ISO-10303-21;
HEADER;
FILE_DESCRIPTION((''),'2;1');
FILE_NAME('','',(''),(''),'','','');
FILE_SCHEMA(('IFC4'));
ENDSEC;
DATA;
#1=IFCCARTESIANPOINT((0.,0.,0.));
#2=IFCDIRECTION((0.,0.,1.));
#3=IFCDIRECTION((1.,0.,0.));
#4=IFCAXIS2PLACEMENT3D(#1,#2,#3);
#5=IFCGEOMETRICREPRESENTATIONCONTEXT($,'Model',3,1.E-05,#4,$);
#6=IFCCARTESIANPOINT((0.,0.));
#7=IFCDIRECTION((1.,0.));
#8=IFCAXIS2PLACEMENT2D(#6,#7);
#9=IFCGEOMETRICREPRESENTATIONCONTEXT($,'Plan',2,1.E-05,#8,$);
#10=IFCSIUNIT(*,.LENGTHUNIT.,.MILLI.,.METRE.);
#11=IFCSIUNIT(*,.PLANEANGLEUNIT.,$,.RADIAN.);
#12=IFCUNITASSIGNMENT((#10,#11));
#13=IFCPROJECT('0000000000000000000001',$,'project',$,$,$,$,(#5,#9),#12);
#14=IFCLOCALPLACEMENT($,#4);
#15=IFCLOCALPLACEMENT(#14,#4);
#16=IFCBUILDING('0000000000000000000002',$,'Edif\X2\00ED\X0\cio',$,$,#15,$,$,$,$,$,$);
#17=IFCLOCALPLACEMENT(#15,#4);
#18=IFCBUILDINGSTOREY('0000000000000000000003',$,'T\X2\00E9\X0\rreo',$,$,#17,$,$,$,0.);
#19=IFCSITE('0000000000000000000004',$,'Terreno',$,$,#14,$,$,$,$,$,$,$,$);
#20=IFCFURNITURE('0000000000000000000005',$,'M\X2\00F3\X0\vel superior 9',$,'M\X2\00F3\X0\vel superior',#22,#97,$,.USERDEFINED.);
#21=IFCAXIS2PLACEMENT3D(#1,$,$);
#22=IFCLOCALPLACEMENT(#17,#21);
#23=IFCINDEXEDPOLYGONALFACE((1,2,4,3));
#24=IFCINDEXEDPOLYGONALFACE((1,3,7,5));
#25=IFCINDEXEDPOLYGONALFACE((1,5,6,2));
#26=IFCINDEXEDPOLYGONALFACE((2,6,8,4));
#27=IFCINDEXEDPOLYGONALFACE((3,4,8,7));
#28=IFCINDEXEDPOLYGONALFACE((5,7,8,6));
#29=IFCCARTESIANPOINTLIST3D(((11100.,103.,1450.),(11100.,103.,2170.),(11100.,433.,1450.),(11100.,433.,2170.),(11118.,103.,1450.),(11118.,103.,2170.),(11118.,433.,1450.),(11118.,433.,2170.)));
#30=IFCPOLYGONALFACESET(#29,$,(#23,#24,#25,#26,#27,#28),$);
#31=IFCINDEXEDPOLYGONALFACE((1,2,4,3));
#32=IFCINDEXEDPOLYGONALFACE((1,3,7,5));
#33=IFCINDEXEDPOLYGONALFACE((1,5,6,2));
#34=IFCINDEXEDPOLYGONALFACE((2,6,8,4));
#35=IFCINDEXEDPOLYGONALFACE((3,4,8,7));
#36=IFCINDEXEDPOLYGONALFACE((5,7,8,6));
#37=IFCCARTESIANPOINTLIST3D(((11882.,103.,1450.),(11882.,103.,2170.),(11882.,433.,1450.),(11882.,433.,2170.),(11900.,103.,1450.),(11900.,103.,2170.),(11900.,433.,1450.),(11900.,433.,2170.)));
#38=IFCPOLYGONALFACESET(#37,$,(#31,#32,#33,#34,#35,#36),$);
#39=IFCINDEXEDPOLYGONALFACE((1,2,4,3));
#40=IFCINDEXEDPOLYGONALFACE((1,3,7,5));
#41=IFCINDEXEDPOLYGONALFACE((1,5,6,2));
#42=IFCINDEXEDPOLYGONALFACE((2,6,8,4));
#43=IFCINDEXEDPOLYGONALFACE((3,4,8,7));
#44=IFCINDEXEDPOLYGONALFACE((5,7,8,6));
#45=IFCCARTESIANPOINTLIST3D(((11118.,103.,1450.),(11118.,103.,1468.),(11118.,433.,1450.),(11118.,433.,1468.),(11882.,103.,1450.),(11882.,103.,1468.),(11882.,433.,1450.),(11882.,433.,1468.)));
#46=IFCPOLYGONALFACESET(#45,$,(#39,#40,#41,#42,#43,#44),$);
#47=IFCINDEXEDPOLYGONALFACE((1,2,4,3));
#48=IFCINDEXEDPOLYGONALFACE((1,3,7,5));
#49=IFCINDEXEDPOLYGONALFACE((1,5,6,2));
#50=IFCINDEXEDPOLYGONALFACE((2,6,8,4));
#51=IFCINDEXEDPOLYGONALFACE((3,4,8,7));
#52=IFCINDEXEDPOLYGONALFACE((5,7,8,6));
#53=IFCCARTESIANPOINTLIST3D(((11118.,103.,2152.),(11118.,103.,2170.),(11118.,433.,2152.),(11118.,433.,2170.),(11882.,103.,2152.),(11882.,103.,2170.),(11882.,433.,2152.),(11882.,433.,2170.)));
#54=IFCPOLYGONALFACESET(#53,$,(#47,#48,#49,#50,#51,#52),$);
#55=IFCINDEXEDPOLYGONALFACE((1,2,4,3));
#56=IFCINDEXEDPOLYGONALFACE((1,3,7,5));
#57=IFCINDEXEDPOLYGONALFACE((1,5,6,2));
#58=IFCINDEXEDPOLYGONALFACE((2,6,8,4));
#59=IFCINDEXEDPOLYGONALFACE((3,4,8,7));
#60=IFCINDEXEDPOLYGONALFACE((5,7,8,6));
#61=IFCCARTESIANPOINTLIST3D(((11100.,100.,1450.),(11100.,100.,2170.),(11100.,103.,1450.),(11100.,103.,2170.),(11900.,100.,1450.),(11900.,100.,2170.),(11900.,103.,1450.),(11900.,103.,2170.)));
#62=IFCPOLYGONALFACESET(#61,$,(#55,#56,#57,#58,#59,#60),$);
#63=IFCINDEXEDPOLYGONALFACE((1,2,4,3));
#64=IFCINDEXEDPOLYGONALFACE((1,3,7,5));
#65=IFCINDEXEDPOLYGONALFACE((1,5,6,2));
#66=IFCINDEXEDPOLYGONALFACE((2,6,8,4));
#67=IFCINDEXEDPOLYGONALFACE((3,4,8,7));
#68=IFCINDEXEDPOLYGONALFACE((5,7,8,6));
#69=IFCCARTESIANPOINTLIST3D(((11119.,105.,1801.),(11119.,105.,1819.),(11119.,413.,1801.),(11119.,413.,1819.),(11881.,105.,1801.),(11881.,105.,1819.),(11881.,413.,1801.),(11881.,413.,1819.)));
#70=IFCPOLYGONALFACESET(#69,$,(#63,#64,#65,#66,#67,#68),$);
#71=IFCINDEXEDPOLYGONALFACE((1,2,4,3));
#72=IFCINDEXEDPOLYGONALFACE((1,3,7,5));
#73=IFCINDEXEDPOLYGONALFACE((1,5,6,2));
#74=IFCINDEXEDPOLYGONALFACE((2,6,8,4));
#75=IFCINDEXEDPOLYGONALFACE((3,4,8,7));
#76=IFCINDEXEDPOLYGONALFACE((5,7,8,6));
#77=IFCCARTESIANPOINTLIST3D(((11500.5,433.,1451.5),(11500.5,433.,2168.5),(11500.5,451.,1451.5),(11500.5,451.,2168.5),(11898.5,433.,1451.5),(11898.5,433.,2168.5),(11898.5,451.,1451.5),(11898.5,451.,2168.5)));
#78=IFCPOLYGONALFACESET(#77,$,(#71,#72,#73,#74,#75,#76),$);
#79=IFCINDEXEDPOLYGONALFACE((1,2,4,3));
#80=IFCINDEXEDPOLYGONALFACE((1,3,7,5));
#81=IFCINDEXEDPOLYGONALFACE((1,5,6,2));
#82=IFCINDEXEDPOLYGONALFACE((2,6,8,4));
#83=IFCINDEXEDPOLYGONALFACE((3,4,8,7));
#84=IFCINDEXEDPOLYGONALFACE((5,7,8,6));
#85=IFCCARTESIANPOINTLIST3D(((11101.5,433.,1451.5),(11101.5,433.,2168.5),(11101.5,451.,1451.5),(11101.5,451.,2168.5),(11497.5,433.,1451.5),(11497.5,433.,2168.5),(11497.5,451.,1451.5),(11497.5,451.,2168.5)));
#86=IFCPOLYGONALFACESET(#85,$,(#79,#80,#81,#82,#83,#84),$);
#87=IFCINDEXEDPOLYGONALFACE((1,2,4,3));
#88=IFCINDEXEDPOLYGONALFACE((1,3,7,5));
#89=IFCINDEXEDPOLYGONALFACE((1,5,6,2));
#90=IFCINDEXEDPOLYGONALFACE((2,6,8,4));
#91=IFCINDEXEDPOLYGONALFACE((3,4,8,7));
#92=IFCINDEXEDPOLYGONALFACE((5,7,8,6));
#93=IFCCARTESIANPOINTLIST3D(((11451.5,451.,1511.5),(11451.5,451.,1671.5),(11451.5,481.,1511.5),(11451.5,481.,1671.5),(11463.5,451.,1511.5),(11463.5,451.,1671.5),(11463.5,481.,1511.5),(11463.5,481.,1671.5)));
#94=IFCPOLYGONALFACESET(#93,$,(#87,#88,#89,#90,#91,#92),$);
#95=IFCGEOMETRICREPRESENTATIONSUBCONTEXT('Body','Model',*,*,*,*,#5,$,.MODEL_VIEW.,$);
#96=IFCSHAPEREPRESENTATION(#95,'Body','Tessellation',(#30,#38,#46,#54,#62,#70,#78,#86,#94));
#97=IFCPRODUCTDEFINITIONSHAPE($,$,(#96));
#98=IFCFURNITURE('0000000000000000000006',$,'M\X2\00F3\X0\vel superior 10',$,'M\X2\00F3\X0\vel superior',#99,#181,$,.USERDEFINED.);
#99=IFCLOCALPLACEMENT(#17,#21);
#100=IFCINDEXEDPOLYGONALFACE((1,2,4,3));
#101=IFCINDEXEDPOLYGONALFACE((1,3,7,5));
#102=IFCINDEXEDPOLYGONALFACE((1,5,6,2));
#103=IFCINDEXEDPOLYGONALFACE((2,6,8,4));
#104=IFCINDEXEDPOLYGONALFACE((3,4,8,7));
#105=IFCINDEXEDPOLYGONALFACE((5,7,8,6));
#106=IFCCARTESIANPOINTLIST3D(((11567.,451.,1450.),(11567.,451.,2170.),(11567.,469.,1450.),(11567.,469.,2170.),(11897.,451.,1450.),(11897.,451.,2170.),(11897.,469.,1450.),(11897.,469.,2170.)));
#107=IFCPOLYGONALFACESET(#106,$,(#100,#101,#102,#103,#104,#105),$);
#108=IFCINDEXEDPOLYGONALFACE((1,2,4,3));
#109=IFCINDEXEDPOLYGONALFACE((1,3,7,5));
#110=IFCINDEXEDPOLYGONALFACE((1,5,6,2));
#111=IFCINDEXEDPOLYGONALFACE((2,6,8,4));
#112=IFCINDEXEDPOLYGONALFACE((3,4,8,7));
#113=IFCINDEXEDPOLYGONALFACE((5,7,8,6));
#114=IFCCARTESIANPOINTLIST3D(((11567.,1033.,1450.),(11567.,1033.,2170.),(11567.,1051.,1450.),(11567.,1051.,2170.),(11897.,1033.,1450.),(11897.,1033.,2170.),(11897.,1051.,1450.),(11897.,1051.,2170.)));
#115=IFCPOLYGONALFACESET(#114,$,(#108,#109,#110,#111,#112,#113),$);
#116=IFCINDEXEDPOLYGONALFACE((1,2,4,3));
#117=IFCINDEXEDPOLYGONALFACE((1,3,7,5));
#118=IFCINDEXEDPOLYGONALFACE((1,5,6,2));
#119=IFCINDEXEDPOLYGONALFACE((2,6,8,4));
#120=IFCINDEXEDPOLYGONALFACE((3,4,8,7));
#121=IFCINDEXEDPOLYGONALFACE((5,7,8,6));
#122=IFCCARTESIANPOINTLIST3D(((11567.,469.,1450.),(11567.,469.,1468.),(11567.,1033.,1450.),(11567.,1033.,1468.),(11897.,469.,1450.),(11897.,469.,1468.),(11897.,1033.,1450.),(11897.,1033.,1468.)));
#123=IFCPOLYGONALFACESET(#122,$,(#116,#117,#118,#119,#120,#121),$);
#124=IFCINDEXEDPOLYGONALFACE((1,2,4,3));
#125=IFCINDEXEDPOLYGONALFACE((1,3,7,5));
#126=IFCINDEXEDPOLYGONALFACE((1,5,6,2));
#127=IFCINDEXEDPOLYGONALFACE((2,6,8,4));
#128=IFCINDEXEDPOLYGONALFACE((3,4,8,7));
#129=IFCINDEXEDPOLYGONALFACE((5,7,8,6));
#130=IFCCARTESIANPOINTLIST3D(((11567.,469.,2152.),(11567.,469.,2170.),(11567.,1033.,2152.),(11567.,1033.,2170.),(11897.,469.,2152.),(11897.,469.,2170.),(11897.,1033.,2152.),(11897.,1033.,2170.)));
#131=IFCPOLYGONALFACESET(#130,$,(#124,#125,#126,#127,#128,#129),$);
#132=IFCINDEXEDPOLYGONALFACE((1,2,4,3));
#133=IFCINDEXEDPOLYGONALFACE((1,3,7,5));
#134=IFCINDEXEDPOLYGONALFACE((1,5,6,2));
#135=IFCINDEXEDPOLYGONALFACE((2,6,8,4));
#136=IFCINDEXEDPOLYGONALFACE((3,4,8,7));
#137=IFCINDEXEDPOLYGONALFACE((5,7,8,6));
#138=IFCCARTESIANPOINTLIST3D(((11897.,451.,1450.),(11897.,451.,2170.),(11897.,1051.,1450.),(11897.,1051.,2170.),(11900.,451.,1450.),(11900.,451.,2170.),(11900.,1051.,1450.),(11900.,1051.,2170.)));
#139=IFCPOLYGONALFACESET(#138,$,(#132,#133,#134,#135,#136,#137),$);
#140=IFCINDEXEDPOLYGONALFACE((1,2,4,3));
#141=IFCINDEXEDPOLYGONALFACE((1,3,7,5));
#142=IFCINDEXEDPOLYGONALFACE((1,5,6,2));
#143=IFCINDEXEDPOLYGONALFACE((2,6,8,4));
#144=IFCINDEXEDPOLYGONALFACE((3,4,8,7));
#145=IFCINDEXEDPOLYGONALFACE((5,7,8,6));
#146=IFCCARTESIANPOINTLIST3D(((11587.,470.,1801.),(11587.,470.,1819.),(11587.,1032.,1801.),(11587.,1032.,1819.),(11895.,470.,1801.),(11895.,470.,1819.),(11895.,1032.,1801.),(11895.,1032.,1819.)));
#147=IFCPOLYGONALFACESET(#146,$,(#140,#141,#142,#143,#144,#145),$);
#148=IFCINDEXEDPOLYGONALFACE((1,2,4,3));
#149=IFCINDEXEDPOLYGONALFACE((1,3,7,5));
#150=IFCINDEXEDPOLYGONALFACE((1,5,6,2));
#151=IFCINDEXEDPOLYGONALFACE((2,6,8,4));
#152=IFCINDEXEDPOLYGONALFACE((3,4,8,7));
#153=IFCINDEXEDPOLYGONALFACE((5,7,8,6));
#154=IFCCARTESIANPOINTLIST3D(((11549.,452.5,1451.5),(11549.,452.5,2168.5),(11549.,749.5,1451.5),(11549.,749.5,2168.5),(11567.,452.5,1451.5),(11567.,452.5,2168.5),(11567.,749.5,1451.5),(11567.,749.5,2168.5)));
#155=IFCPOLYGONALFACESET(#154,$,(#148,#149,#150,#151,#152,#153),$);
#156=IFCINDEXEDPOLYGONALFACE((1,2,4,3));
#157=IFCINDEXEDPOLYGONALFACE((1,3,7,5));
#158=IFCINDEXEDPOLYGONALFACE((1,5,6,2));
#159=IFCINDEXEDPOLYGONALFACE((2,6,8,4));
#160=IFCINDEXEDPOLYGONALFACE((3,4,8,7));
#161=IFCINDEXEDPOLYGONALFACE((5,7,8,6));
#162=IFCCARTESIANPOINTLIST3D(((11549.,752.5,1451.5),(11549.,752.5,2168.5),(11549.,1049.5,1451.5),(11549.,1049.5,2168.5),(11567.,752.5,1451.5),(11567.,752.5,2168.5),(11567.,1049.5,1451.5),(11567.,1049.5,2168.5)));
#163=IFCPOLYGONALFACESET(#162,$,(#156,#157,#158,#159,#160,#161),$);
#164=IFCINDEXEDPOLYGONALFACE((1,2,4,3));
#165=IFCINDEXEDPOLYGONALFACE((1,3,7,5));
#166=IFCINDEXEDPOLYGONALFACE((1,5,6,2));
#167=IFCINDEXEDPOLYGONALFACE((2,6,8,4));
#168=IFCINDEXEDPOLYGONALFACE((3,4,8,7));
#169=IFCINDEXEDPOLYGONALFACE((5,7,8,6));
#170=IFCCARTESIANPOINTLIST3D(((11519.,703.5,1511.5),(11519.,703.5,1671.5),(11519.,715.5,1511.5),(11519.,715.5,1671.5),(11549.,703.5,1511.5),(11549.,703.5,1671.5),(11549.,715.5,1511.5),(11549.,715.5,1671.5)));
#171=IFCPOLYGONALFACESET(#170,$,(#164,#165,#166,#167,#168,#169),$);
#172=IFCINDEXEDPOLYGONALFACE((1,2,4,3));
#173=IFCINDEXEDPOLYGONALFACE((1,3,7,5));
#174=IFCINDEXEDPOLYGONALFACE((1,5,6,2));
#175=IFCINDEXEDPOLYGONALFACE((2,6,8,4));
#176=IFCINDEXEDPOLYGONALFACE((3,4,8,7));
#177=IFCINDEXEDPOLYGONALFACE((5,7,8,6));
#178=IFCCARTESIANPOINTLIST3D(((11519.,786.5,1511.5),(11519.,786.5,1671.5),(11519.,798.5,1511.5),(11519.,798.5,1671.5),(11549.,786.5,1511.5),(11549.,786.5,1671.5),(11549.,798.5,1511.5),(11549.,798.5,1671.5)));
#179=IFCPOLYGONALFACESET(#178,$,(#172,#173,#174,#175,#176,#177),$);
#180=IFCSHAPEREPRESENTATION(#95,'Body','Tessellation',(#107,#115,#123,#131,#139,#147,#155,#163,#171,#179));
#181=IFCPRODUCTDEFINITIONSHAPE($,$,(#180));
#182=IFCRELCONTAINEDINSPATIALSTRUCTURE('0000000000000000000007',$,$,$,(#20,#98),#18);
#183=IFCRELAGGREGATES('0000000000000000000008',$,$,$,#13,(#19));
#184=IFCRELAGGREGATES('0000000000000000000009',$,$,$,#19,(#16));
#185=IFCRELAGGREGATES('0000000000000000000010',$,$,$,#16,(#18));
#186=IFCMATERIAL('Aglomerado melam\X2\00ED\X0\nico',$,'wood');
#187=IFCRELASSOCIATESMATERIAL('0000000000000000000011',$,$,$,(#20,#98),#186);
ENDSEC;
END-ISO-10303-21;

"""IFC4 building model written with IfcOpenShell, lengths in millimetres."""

from ifc_helpers import new_model, si_unit, frame, frame_2d, origin_with_axes, origin_2d_with_axis, place, context, subcontext, project, spatial, rectangle, extrude, material, element, save


model = new_model("IFC4")

# Units and contexts
model_context = context("Model", 3, precision=1e-05, world=origin_with_axes())
plan_context = context("Plan", 2, precision=1e-05, world=origin_2d_with_axis())
body_context = subcontext(model_context, "Body", "Model", "MODEL_VIEW")
ifc_project = project(units=[si_unit("LENGTHUNIT", "METRE", prefix="MILLI"), si_unit("PLANEANGLEUNIT", "RADIAN")], contexts=[model_context, plan_context])

# Site, building, storey
site_placement = place(None, origin_with_axes())
site = spatial("IfcSite", under=ifc_project, at=site_placement, Name="Terreno")
building_placement = place(site_placement, origin_with_axes())
building = spatial("IfcBuilding", under=site, at=building_placement, Name="Edifício")
storey_placement = place(building_placement, origin_with_axes())
storey = spatial("IfcBuildingStorey", under=building, at=storey_placement, Name="Térreo", Elevation=0.0)

# Furniture
ifc_material_1 = material(Name="Aglomerado melamínico", Category="wood")
furniture_1_placement = place(storey_placement, frame((11100.0, 100.0, 0.0), z_axis=(0.0, 0.0, 1.0), x_axis=(1.0, 0.0, 0.0)))
element("IfcFurniture", 1, at=furniture_1_placement, inside=storey, material=ifc_material_1, Name="Móvel superior 9", ObjectType="Móvel superior", PredefinedType="USERDEFINED", context=body_context, shape_type="SweptSolid", body=[
    extrude(rectangle(XDim=18.0, YDim=330.0, at=frame_2d((9.0, 168.0))), frame((0.0, 0.0, 1450.0)), (0.0, 0.0, 1.0), 720.0),
    extrude(rectangle(XDim=18.0, YDim=330.0, at=frame_2d((791.0, 168.0))), frame((0.0, 0.0, 1450.0)), (0.0, 0.0, 1.0), 720.0),
    extrude(rectangle(XDim=764.0, YDim=330.0, at=frame_2d((400.0, 168.0))), frame((0.0, 0.0, 1450.0)), (0.0, 0.0, 1.0), 18.0),
    extrude(rectangle(XDim=764.0, YDim=330.0, at=frame_2d((400.0, 168.0))), frame((0.0, 0.0, 2152.0)), (0.0, 0.0, 1.0), 18.0),
    extrude(rectangle(XDim=800.0, YDim=3.0, at=frame_2d((400.0, 1.5))), frame((0.0, 0.0, 1450.0)), (0.0, 0.0, 1.0), 720.0),
    extrude(rectangle(XDim=762.0, YDim=308.0, at=frame_2d((400.0, 159.0))), frame((0.0, 0.0, 1801.0)), (0.0, 0.0, 1.0), 18.0),
    extrude(rectangle(XDim=398.0, YDim=18.0, at=frame_2d((599.5, 342.0))), frame((0.0, 0.0, 1451.5)), (0.0, 0.0, 1.0), 717.0),
    extrude(rectangle(XDim=396.0, YDim=18.0, at=frame_2d((199.5, 342.0))), frame((0.0, 0.0, 1451.5)), (0.0, 0.0, 1.0), 717.0),
    extrude(rectangle(XDim=12.0, YDim=30.0, at=frame_2d((357.5, 366.0))), frame((0.0, 0.0, 1511.5)), (0.0, 0.0, 1.0), 160.0),
])
furniture_2_placement = place(storey_placement, frame((11900.0, 451.0, 0.0), z_axis=(0.0, 0.0, 1.0), x_axis=(0.0, 1.0, 0.0)))
element("IfcFurniture", 2, at=furniture_2_placement, inside=storey, material=ifc_material_1, Name="Móvel superior 10", ObjectType="Móvel superior", PredefinedType="USERDEFINED", context=body_context, shape_type="SweptSolid", body=[
    extrude(rectangle(XDim=18.0, YDim=330.0, at=frame_2d((9.0, 168.0))), frame((0.0, 0.0, 1450.0)), (0.0, 0.0, 1.0), 720.0),
    extrude(rectangle(XDim=18.0, YDim=330.0, at=frame_2d((591.0, 168.0))), frame((0.0, 0.0, 1450.0)), (0.0, 0.0, 1.0), 720.0),
    extrude(rectangle(XDim=564.0, YDim=330.0, at=frame_2d((300.0, 168.0))), frame((0.0, 0.0, 1450.0)), (0.0, 0.0, 1.0), 18.0),
    extrude(rectangle(XDim=564.0, YDim=330.0, at=frame_2d((300.0, 168.0))), frame((0.0, 0.0, 2152.0)), (0.0, 0.0, 1.0), 18.0),
    extrude(rectangle(XDim=600.0, YDim=3.0, at=frame_2d((300.0, 1.5))), frame((0.0, 0.0, 1450.0)), (0.0, 0.0, 1.0), 720.0),
    extrude(rectangle(XDim=562.0, YDim=308.0, at=frame_2d((300.0, 159.0))), frame((0.0, 0.0, 1801.0)), (0.0, 0.0, 1.0), 18.0),
    extrude(rectangle(XDim=297.0, YDim=18.0, at=frame_2d((150.0, 342.0))), frame((0.0, 0.0, 1451.5)), (0.0, 0.0, 1.0), 717.0),
    extrude(rectangle(XDim=297.0, YDim=18.0, at=frame_2d((450.0, 342.0))), frame((0.0, 0.0, 1451.5)), (0.0, 0.0, 1.0), 717.0),
    extrude(rectangle(XDim=12.0, YDim=30.0, at=frame_2d((258.5, 366.0))), frame((0.0, 0.0, 1511.5)), (0.0, 0.0, 1.0), 160.0),
    extrude(rectangle(XDim=12.0, YDim=30.0, at=frame_2d((341.5, 366.0))), frame((0.0, 0.0, 1511.5)), (0.0, 0.0, 1.0), 160.0),
])

save(model, "model.ifc")
